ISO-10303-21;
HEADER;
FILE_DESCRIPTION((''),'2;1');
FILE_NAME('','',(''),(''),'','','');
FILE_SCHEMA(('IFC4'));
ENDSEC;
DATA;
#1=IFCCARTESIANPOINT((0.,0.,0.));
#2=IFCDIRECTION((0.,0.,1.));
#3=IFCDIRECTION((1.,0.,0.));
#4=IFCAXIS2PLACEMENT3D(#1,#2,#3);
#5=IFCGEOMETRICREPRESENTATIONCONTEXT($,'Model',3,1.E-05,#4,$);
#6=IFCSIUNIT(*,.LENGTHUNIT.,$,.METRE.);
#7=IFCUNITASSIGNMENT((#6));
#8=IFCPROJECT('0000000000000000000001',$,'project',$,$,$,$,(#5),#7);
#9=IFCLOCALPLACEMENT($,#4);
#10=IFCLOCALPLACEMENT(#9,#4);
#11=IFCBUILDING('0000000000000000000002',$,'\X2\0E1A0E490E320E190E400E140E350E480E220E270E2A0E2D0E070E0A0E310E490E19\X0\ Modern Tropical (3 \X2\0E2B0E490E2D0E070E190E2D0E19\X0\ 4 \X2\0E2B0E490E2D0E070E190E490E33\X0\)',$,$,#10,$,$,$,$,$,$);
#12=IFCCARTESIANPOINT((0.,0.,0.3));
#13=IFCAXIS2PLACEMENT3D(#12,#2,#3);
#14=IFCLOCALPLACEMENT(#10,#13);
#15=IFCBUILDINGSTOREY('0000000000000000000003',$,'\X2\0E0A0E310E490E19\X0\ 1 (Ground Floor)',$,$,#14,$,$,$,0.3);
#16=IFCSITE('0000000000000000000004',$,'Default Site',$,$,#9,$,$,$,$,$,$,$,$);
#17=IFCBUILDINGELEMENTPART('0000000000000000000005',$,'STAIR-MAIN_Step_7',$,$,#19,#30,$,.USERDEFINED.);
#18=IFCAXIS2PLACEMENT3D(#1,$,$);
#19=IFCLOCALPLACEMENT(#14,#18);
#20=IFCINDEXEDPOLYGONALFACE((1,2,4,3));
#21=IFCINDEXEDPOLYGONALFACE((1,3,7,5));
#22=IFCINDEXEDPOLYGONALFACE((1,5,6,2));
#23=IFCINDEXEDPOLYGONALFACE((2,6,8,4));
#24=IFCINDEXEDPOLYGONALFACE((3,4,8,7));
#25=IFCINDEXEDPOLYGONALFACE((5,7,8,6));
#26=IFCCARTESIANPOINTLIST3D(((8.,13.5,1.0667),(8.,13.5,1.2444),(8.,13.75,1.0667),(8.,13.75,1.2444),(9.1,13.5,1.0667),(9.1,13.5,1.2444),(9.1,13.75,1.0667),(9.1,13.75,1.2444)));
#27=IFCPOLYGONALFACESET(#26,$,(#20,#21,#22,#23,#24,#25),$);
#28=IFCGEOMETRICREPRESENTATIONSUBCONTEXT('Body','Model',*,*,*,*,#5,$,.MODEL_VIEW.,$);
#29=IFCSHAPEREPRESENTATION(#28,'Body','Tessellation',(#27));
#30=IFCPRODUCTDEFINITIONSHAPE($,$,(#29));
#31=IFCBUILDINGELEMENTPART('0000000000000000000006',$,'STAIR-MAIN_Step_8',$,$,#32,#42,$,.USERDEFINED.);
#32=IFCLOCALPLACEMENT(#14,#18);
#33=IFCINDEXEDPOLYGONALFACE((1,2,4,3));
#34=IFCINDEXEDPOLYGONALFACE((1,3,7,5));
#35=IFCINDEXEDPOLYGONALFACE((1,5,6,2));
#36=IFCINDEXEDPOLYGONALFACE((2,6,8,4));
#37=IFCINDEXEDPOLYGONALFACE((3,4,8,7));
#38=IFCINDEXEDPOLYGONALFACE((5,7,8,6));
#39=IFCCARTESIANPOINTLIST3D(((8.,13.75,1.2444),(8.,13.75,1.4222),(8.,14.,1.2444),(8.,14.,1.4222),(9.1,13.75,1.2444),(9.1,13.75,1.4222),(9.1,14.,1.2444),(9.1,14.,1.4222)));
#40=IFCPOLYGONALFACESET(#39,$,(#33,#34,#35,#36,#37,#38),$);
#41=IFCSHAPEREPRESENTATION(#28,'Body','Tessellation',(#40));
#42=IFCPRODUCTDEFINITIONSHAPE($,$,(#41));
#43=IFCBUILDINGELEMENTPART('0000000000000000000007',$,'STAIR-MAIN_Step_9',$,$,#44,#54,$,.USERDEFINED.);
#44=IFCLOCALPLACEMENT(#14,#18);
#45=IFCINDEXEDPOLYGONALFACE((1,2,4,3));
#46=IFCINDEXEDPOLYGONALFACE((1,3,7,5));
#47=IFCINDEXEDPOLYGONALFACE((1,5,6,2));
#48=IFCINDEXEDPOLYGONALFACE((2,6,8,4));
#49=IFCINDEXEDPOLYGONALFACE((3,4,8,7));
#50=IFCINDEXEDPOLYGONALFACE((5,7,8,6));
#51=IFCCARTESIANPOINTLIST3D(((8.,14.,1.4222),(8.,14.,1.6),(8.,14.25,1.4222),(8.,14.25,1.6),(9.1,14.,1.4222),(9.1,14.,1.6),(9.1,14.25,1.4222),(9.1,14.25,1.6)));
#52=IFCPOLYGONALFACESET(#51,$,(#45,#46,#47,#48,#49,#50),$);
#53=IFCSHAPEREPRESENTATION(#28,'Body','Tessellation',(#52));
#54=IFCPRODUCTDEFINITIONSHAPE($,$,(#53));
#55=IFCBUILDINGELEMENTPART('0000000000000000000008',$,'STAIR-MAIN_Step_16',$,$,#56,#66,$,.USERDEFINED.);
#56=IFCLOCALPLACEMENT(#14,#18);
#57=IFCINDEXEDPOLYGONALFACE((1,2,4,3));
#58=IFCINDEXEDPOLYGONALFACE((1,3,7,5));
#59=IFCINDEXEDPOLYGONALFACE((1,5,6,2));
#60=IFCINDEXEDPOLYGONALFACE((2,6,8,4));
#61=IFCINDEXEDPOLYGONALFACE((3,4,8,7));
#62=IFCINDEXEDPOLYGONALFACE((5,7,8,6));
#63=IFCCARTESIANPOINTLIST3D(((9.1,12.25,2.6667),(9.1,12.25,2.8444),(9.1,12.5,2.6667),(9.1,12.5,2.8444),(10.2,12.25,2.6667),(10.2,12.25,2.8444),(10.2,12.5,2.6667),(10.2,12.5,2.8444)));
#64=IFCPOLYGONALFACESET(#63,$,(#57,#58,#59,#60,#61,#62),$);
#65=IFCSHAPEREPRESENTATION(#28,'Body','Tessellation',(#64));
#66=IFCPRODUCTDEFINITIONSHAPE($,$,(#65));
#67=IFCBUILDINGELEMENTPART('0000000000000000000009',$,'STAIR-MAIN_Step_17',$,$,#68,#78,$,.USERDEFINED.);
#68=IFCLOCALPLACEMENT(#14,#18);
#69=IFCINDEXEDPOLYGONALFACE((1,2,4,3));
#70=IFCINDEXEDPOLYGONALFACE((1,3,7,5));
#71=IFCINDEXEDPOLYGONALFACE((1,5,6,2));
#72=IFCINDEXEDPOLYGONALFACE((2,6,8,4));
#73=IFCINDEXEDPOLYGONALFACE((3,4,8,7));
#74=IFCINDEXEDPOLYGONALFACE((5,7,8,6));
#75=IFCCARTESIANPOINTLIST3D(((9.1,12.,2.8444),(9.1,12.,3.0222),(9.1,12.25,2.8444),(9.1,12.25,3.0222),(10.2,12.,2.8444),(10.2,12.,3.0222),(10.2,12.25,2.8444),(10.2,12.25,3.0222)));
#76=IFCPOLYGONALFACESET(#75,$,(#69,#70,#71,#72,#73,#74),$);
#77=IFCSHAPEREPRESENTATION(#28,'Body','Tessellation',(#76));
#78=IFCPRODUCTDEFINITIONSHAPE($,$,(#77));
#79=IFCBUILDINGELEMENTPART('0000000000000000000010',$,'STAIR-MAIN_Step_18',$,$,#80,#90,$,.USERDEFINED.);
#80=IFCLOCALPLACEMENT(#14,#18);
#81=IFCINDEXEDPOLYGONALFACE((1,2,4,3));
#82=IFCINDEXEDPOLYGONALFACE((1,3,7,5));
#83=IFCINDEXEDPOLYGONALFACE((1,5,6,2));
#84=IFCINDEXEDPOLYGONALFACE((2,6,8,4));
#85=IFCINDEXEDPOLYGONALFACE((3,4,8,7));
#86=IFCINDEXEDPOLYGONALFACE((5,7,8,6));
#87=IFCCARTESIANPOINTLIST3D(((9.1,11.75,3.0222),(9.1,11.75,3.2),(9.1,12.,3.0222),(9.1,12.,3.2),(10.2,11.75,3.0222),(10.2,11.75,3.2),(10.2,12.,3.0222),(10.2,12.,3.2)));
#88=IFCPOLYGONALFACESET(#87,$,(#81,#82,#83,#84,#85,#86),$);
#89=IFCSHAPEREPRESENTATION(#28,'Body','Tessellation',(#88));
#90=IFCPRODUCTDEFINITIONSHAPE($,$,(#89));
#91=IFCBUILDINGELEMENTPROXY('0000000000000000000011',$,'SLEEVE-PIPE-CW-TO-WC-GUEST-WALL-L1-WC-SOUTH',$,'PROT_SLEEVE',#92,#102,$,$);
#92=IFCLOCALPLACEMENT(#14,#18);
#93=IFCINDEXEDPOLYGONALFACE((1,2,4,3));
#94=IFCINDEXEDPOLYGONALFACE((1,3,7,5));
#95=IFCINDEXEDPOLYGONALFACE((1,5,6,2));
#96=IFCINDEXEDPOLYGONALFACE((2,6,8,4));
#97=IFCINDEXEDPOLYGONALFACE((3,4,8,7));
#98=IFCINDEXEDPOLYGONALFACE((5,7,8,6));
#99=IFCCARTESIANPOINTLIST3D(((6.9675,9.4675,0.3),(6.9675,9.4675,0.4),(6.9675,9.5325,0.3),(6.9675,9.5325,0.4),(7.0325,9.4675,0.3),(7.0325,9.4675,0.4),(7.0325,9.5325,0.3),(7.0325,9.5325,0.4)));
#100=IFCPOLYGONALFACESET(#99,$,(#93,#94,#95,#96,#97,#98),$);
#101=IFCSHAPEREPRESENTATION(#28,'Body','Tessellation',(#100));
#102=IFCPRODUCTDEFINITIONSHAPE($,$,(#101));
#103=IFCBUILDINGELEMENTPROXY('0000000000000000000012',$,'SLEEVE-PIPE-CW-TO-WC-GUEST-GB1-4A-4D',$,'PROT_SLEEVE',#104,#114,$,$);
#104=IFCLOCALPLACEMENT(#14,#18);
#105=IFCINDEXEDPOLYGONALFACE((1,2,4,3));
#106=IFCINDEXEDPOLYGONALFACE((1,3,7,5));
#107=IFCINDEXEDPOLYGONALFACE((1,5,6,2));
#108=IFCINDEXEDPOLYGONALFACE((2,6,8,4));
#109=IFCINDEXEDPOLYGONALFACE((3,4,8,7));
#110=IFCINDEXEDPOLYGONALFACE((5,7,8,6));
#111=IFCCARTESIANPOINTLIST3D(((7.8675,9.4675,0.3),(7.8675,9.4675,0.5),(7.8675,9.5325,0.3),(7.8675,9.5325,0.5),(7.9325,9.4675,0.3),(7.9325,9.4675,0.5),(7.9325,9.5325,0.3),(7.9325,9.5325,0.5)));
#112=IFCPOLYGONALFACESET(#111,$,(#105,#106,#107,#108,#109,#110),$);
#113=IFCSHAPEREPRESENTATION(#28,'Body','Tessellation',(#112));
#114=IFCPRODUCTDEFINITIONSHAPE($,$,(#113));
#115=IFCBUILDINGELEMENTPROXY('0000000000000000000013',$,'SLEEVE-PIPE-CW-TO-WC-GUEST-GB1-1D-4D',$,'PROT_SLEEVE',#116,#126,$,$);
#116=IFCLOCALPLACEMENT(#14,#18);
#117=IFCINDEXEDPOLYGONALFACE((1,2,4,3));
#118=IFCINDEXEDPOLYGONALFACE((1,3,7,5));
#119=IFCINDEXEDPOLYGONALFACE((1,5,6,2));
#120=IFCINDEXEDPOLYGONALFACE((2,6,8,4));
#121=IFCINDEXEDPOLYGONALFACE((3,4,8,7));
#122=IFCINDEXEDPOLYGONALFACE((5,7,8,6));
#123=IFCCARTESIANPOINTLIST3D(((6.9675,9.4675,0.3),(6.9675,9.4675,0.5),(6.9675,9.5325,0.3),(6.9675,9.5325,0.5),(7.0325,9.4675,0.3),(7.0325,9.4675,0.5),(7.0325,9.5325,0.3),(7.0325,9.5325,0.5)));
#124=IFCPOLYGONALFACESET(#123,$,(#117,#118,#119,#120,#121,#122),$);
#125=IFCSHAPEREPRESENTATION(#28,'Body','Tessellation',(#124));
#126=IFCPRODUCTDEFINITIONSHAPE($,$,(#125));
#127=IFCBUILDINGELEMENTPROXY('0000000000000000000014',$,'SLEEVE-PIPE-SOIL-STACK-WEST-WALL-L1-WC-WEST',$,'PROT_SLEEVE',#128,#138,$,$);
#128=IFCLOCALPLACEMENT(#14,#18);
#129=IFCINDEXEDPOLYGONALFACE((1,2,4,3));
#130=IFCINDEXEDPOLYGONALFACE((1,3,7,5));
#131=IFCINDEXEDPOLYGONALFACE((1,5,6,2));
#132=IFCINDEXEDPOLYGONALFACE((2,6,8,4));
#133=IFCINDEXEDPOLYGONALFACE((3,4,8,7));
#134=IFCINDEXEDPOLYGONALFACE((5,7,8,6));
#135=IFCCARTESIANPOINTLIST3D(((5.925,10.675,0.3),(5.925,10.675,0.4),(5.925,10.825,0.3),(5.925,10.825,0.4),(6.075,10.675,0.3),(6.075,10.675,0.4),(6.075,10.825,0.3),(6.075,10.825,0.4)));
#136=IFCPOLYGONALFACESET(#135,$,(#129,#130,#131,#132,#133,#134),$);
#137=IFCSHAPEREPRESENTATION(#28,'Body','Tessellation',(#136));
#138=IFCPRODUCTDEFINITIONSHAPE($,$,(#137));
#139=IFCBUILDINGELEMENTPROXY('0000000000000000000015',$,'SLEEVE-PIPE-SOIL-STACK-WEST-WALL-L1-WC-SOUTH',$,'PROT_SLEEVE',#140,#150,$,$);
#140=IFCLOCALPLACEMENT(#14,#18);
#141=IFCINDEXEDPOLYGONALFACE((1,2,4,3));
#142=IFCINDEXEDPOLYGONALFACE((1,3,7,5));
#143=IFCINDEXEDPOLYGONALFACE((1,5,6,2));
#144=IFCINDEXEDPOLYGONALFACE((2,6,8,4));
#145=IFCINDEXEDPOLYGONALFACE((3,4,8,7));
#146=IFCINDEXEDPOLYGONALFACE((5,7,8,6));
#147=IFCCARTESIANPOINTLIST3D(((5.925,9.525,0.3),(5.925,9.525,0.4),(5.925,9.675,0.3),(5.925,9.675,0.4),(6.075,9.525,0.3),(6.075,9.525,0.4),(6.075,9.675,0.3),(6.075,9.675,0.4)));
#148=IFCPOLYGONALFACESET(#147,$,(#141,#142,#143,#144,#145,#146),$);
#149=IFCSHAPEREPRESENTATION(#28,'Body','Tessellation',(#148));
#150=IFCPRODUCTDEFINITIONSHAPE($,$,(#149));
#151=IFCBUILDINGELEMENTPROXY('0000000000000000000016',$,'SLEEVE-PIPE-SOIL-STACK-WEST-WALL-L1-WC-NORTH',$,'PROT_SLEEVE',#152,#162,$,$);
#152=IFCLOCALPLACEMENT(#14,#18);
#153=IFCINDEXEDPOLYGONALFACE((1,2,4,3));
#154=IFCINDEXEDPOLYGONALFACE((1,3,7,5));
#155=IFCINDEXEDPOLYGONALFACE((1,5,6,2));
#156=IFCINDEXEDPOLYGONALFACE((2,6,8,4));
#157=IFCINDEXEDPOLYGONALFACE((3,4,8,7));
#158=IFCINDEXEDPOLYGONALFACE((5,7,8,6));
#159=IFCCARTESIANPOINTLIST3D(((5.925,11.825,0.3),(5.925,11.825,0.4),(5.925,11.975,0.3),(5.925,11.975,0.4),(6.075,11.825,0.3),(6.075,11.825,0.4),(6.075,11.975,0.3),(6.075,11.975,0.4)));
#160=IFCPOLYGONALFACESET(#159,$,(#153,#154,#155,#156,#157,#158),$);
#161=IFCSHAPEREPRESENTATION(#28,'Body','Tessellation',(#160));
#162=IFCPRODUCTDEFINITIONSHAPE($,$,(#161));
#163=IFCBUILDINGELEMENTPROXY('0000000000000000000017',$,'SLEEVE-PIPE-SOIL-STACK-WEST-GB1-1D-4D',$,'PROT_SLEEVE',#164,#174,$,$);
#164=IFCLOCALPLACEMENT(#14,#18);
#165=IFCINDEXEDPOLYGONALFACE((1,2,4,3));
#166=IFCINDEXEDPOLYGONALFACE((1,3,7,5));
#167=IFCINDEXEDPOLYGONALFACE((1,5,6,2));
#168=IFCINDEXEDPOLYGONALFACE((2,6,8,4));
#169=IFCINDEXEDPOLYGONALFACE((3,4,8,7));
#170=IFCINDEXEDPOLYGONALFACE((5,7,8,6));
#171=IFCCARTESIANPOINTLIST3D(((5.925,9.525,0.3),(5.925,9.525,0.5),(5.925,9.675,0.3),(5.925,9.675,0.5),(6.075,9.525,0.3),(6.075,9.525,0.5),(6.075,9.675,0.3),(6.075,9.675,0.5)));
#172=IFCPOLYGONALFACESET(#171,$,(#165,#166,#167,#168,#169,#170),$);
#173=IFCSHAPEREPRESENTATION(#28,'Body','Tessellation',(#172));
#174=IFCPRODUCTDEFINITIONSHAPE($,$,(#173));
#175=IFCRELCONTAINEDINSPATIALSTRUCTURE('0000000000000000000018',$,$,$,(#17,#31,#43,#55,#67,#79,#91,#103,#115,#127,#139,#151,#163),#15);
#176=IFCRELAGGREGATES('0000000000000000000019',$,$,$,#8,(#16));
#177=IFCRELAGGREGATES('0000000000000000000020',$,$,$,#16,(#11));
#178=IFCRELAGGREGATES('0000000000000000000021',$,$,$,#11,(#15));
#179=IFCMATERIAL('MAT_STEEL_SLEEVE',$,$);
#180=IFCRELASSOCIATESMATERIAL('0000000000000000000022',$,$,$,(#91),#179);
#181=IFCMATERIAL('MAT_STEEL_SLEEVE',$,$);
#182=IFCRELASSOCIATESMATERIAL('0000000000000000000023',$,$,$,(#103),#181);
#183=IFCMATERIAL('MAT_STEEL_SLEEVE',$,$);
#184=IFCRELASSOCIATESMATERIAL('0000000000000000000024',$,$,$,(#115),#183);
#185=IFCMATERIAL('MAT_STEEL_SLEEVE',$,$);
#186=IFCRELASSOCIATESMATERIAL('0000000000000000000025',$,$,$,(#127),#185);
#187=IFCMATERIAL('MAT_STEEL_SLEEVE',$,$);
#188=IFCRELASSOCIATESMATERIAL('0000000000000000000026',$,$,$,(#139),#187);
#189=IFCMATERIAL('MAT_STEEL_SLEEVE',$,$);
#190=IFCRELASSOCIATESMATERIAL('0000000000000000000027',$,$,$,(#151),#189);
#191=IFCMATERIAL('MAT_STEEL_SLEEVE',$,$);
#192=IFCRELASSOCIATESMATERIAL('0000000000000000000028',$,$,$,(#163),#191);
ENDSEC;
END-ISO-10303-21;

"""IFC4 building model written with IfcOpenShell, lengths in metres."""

from ifc_helpers import new_model, si_unit, frame, origin_with_axes, origin_2d, place, context, subcontext, project, spatial, rectangle, extrude, material, element, save


model = new_model("IFC4")

# Units and contexts
model_context = context("Model", 3, precision=1e-05, world=origin_with_axes())
body_context = subcontext(model_context, "Body", "Model", "MODEL_VIEW")
ifc_project = project(units=[si_unit("LENGTHUNIT", "METRE")], contexts=[model_context])

# Site, building, storey
site_placement = place(None, origin_with_axes())
site = spatial("IfcSite", under=ifc_project, at=site_placement, Name="Default Site")
building_placement = place(site_placement, origin_with_axes())
building = spatial("IfcBuilding", under=site, at=building_placement, Name="บ้านเดี่ยวสองชั้น Modern Tropical (3 ห้องนอน 4 ห้องน้ำ)")
storey_placement = place(building_placement, frame((0.0, 0.0, 0.3), z_axis=(0.0, 0.0, 1.0), x_axis=(1.0, 0.0, 0.0)))
storey = spatial("IfcBuildingStorey", under=building, at=storey_placement, Name="ชั้น 1 (Ground Floor)", Elevation=0.3)

# Building element parts
for number, where, z_axis, x_axis, name in (
    (1, (8.55, 13.625, 1.0667), (0.0, 0.0, 1.0), (1.0, 0.0, 0.0), "STAIR-MAIN_Step_7"),
    (2, (8.55, 13.875, 1.2444), (0.0, 0.0, 1.0), (1.0, 0.0, 0.0), "STAIR-MAIN_Step_8"),
    (3, (8.55, 14.125, 1.4222), (0.0, 0.0, 1.0), (1.0, 0.0, 0.0), "STAIR-MAIN_Step_9"),
    (4, (9.65, 12.375, 2.6667), (0.0, 0.0, 1.0), (1.0, 0.0, 0.0), "STAIR-MAIN_Step_16"),
    (5, (9.65, 12.125, 2.8444), (0.0, 0.0, 1.0), (1.0, 0.0, 0.0), "STAIR-MAIN_Step_17"),
    (6, (9.65, 11.875, 3.0222), (0.0, 0.0, 1.0), (1.0, 0.0, 0.0), "STAIR-MAIN_Step_18"),
):
    element("IfcBuildingElementPart", number, at=place(storey_placement, frame(where, z_axis=z_axis, x_axis=x_axis)), inside=storey, Name=name, PredefinedType="USERDEFINED", context=body_context, shape_type="SweptSolid", body=[
        extrude(rectangle(XDim=1.1, YDim=0.25, at=origin_2d()), origin_with_axes(), (0.0, 0.0, 1.0), 0.1778),
    ])

# Building element proxies
ifc_material_1 = material(Name="MAT_STEEL_SLEEVE")
proxy_1_placement = place(storey_placement, frame((7.0, 9.5, 0.3), z_axis=(0.0, 0.0, 1.0), x_axis=(1.0, 0.0, 0.0)))
element("IfcBuildingElementProxy", 7, at=proxy_1_placement, inside=storey, material=ifc_material_1, Name="SLEEVE-PIPE-CW-TO-WC-GUEST-WALL-L1-WC-SOUTH", ObjectType="PROT_SLEEVE", context=body_context, shape_type="SweptSolid", body=[
    extrude(rectangle(XDim=0.065, YDim=0.065, at=origin_2d()), origin_with_axes(), (0.0, 0.0, 1.0), 0.1),
])
ifc_material_2 = material(Name="MAT_STEEL_SLEEVE")
proxy_2_placement = place(storey_placement, frame((7.9, 9.5, 0.3), z_axis=(0.0, 0.0, 1.0), x_axis=(1.0, 0.0, 0.0)))
element("IfcBuildingElementProxy", 8, at=proxy_2_placement, inside=storey, material=ifc_material_2, Name="SLEEVE-PIPE-CW-TO-WC-GUEST-GB1-4A-4D", ObjectType="PROT_SLEEVE", context=body_context, shape_type="SweptSolid", body=[
    extrude(rectangle(XDim=0.065, YDim=0.065, at=origin_2d()), origin_with_axes(), (0.0, 0.0, 1.0), 0.2),
])
ifc_material_3 = material(Name="MAT_STEEL_SLEEVE")
proxy_3_placement = place(storey_placement, frame((7.0, 9.5, 0.3), z_axis=(0.0, 0.0, 1.0), x_axis=(1.0, 0.0, 0.0)))
element("IfcBuildingElementProxy", 9, at=proxy_3_placement, inside=storey, material=ifc_material_3, Name="SLEEVE-PIPE-CW-TO-WC-GUEST-GB1-1D-4D", ObjectType="PROT_SLEEVE", context=body_context, shape_type="SweptSolid", body=[
    extrude(rectangle(XDim=0.065, YDim=0.065, at=origin_2d()), origin_with_axes(), (0.0, 0.0, 1.0), 0.2),
])
ifc_material_4 = material(Name="MAT_STEEL_SLEEVE")
proxy_4_placement = place(storey_placement, frame((6.0, 10.75, 0.3), z_axis=(0.0, 0.0, 1.0), x_axis=(1.0, 0.0, 0.0)))
element("IfcBuildingElementProxy", 10, at=proxy_4_placement, inside=storey, material=ifc_material_4, Name="SLEEVE-PIPE-SOIL-STACK-WEST-WALL-L1-WC-WEST", ObjectType="PROT_SLEEVE", context=body_context, shape_type="SweptSolid", body=[
    extrude(rectangle(XDim=0.15, YDim=0.15, at=origin_2d()), origin_with_axes(), (0.0, 0.0, 1.0), 0.1),
])
ifc_material_5 = material(Name="MAT_STEEL_SLEEVE")
proxy_5_placement = place(storey_placement, frame((6.0, 9.6, 0.3), z_axis=(0.0, 0.0, 1.0), x_axis=(1.0, 0.0, 0.0)))
element("IfcBuildingElementProxy", 11, at=proxy_5_placement, inside=storey, material=ifc_material_5, Name="SLEEVE-PIPE-SOIL-STACK-WEST-WALL-L1-WC-SOUTH", ObjectType="PROT_SLEEVE", context=body_context, shape_type="SweptSolid", body=[
    extrude(rectangle(XDim=0.15, YDim=0.15, at=origin_2d()), origin_with_axes(), (0.0, 0.0, 1.0), 0.1),
])
ifc_material_6 = material(Name="MAT_STEEL_SLEEVE")
proxy_6_placement = place(storey_placement, frame((6.0, 11.9, 0.3), z_axis=(0.0, 0.0, 1.0), x_axis=(1.0, 0.0, 0.0)))
element("IfcBuildingElementProxy", 12, at=proxy_6_placement, inside=storey, material=ifc_material_6, Name="SLEEVE-PIPE-SOIL-STACK-WEST-WALL-L1-WC-NORTH", ObjectType="PROT_SLEEVE", context=body_context, shape_type="SweptSolid", body=[
    extrude(rectangle(XDim=0.15, YDim=0.15, at=origin_2d()), origin_with_axes(), (0.0, 0.0, 1.0), 0.1),
])
ifc_material_7 = material(Name="MAT_STEEL_SLEEVE")
proxy_7_placement = place(storey_placement, frame((6.0, 9.6, 0.3), z_axis=(0.0, 0.0, 1.0), x_axis=(1.0, 0.0, 0.0)))
element("IfcBuildingElementProxy", 13, at=proxy_7_placement, inside=storey, material=ifc_material_7, Name="SLEEVE-PIPE-SOIL-STACK-WEST-GB1-1D-4D", ObjectType="PROT_SLEEVE", context=body_context, shape_type="SweptSolid", body=[
    extrude(rectangle(XDim=0.15, YDim=0.15, at=origin_2d()), origin_with_axes(), (0.0, 0.0, 1.0), 0.2),
])

save(model, "model.ifc")
